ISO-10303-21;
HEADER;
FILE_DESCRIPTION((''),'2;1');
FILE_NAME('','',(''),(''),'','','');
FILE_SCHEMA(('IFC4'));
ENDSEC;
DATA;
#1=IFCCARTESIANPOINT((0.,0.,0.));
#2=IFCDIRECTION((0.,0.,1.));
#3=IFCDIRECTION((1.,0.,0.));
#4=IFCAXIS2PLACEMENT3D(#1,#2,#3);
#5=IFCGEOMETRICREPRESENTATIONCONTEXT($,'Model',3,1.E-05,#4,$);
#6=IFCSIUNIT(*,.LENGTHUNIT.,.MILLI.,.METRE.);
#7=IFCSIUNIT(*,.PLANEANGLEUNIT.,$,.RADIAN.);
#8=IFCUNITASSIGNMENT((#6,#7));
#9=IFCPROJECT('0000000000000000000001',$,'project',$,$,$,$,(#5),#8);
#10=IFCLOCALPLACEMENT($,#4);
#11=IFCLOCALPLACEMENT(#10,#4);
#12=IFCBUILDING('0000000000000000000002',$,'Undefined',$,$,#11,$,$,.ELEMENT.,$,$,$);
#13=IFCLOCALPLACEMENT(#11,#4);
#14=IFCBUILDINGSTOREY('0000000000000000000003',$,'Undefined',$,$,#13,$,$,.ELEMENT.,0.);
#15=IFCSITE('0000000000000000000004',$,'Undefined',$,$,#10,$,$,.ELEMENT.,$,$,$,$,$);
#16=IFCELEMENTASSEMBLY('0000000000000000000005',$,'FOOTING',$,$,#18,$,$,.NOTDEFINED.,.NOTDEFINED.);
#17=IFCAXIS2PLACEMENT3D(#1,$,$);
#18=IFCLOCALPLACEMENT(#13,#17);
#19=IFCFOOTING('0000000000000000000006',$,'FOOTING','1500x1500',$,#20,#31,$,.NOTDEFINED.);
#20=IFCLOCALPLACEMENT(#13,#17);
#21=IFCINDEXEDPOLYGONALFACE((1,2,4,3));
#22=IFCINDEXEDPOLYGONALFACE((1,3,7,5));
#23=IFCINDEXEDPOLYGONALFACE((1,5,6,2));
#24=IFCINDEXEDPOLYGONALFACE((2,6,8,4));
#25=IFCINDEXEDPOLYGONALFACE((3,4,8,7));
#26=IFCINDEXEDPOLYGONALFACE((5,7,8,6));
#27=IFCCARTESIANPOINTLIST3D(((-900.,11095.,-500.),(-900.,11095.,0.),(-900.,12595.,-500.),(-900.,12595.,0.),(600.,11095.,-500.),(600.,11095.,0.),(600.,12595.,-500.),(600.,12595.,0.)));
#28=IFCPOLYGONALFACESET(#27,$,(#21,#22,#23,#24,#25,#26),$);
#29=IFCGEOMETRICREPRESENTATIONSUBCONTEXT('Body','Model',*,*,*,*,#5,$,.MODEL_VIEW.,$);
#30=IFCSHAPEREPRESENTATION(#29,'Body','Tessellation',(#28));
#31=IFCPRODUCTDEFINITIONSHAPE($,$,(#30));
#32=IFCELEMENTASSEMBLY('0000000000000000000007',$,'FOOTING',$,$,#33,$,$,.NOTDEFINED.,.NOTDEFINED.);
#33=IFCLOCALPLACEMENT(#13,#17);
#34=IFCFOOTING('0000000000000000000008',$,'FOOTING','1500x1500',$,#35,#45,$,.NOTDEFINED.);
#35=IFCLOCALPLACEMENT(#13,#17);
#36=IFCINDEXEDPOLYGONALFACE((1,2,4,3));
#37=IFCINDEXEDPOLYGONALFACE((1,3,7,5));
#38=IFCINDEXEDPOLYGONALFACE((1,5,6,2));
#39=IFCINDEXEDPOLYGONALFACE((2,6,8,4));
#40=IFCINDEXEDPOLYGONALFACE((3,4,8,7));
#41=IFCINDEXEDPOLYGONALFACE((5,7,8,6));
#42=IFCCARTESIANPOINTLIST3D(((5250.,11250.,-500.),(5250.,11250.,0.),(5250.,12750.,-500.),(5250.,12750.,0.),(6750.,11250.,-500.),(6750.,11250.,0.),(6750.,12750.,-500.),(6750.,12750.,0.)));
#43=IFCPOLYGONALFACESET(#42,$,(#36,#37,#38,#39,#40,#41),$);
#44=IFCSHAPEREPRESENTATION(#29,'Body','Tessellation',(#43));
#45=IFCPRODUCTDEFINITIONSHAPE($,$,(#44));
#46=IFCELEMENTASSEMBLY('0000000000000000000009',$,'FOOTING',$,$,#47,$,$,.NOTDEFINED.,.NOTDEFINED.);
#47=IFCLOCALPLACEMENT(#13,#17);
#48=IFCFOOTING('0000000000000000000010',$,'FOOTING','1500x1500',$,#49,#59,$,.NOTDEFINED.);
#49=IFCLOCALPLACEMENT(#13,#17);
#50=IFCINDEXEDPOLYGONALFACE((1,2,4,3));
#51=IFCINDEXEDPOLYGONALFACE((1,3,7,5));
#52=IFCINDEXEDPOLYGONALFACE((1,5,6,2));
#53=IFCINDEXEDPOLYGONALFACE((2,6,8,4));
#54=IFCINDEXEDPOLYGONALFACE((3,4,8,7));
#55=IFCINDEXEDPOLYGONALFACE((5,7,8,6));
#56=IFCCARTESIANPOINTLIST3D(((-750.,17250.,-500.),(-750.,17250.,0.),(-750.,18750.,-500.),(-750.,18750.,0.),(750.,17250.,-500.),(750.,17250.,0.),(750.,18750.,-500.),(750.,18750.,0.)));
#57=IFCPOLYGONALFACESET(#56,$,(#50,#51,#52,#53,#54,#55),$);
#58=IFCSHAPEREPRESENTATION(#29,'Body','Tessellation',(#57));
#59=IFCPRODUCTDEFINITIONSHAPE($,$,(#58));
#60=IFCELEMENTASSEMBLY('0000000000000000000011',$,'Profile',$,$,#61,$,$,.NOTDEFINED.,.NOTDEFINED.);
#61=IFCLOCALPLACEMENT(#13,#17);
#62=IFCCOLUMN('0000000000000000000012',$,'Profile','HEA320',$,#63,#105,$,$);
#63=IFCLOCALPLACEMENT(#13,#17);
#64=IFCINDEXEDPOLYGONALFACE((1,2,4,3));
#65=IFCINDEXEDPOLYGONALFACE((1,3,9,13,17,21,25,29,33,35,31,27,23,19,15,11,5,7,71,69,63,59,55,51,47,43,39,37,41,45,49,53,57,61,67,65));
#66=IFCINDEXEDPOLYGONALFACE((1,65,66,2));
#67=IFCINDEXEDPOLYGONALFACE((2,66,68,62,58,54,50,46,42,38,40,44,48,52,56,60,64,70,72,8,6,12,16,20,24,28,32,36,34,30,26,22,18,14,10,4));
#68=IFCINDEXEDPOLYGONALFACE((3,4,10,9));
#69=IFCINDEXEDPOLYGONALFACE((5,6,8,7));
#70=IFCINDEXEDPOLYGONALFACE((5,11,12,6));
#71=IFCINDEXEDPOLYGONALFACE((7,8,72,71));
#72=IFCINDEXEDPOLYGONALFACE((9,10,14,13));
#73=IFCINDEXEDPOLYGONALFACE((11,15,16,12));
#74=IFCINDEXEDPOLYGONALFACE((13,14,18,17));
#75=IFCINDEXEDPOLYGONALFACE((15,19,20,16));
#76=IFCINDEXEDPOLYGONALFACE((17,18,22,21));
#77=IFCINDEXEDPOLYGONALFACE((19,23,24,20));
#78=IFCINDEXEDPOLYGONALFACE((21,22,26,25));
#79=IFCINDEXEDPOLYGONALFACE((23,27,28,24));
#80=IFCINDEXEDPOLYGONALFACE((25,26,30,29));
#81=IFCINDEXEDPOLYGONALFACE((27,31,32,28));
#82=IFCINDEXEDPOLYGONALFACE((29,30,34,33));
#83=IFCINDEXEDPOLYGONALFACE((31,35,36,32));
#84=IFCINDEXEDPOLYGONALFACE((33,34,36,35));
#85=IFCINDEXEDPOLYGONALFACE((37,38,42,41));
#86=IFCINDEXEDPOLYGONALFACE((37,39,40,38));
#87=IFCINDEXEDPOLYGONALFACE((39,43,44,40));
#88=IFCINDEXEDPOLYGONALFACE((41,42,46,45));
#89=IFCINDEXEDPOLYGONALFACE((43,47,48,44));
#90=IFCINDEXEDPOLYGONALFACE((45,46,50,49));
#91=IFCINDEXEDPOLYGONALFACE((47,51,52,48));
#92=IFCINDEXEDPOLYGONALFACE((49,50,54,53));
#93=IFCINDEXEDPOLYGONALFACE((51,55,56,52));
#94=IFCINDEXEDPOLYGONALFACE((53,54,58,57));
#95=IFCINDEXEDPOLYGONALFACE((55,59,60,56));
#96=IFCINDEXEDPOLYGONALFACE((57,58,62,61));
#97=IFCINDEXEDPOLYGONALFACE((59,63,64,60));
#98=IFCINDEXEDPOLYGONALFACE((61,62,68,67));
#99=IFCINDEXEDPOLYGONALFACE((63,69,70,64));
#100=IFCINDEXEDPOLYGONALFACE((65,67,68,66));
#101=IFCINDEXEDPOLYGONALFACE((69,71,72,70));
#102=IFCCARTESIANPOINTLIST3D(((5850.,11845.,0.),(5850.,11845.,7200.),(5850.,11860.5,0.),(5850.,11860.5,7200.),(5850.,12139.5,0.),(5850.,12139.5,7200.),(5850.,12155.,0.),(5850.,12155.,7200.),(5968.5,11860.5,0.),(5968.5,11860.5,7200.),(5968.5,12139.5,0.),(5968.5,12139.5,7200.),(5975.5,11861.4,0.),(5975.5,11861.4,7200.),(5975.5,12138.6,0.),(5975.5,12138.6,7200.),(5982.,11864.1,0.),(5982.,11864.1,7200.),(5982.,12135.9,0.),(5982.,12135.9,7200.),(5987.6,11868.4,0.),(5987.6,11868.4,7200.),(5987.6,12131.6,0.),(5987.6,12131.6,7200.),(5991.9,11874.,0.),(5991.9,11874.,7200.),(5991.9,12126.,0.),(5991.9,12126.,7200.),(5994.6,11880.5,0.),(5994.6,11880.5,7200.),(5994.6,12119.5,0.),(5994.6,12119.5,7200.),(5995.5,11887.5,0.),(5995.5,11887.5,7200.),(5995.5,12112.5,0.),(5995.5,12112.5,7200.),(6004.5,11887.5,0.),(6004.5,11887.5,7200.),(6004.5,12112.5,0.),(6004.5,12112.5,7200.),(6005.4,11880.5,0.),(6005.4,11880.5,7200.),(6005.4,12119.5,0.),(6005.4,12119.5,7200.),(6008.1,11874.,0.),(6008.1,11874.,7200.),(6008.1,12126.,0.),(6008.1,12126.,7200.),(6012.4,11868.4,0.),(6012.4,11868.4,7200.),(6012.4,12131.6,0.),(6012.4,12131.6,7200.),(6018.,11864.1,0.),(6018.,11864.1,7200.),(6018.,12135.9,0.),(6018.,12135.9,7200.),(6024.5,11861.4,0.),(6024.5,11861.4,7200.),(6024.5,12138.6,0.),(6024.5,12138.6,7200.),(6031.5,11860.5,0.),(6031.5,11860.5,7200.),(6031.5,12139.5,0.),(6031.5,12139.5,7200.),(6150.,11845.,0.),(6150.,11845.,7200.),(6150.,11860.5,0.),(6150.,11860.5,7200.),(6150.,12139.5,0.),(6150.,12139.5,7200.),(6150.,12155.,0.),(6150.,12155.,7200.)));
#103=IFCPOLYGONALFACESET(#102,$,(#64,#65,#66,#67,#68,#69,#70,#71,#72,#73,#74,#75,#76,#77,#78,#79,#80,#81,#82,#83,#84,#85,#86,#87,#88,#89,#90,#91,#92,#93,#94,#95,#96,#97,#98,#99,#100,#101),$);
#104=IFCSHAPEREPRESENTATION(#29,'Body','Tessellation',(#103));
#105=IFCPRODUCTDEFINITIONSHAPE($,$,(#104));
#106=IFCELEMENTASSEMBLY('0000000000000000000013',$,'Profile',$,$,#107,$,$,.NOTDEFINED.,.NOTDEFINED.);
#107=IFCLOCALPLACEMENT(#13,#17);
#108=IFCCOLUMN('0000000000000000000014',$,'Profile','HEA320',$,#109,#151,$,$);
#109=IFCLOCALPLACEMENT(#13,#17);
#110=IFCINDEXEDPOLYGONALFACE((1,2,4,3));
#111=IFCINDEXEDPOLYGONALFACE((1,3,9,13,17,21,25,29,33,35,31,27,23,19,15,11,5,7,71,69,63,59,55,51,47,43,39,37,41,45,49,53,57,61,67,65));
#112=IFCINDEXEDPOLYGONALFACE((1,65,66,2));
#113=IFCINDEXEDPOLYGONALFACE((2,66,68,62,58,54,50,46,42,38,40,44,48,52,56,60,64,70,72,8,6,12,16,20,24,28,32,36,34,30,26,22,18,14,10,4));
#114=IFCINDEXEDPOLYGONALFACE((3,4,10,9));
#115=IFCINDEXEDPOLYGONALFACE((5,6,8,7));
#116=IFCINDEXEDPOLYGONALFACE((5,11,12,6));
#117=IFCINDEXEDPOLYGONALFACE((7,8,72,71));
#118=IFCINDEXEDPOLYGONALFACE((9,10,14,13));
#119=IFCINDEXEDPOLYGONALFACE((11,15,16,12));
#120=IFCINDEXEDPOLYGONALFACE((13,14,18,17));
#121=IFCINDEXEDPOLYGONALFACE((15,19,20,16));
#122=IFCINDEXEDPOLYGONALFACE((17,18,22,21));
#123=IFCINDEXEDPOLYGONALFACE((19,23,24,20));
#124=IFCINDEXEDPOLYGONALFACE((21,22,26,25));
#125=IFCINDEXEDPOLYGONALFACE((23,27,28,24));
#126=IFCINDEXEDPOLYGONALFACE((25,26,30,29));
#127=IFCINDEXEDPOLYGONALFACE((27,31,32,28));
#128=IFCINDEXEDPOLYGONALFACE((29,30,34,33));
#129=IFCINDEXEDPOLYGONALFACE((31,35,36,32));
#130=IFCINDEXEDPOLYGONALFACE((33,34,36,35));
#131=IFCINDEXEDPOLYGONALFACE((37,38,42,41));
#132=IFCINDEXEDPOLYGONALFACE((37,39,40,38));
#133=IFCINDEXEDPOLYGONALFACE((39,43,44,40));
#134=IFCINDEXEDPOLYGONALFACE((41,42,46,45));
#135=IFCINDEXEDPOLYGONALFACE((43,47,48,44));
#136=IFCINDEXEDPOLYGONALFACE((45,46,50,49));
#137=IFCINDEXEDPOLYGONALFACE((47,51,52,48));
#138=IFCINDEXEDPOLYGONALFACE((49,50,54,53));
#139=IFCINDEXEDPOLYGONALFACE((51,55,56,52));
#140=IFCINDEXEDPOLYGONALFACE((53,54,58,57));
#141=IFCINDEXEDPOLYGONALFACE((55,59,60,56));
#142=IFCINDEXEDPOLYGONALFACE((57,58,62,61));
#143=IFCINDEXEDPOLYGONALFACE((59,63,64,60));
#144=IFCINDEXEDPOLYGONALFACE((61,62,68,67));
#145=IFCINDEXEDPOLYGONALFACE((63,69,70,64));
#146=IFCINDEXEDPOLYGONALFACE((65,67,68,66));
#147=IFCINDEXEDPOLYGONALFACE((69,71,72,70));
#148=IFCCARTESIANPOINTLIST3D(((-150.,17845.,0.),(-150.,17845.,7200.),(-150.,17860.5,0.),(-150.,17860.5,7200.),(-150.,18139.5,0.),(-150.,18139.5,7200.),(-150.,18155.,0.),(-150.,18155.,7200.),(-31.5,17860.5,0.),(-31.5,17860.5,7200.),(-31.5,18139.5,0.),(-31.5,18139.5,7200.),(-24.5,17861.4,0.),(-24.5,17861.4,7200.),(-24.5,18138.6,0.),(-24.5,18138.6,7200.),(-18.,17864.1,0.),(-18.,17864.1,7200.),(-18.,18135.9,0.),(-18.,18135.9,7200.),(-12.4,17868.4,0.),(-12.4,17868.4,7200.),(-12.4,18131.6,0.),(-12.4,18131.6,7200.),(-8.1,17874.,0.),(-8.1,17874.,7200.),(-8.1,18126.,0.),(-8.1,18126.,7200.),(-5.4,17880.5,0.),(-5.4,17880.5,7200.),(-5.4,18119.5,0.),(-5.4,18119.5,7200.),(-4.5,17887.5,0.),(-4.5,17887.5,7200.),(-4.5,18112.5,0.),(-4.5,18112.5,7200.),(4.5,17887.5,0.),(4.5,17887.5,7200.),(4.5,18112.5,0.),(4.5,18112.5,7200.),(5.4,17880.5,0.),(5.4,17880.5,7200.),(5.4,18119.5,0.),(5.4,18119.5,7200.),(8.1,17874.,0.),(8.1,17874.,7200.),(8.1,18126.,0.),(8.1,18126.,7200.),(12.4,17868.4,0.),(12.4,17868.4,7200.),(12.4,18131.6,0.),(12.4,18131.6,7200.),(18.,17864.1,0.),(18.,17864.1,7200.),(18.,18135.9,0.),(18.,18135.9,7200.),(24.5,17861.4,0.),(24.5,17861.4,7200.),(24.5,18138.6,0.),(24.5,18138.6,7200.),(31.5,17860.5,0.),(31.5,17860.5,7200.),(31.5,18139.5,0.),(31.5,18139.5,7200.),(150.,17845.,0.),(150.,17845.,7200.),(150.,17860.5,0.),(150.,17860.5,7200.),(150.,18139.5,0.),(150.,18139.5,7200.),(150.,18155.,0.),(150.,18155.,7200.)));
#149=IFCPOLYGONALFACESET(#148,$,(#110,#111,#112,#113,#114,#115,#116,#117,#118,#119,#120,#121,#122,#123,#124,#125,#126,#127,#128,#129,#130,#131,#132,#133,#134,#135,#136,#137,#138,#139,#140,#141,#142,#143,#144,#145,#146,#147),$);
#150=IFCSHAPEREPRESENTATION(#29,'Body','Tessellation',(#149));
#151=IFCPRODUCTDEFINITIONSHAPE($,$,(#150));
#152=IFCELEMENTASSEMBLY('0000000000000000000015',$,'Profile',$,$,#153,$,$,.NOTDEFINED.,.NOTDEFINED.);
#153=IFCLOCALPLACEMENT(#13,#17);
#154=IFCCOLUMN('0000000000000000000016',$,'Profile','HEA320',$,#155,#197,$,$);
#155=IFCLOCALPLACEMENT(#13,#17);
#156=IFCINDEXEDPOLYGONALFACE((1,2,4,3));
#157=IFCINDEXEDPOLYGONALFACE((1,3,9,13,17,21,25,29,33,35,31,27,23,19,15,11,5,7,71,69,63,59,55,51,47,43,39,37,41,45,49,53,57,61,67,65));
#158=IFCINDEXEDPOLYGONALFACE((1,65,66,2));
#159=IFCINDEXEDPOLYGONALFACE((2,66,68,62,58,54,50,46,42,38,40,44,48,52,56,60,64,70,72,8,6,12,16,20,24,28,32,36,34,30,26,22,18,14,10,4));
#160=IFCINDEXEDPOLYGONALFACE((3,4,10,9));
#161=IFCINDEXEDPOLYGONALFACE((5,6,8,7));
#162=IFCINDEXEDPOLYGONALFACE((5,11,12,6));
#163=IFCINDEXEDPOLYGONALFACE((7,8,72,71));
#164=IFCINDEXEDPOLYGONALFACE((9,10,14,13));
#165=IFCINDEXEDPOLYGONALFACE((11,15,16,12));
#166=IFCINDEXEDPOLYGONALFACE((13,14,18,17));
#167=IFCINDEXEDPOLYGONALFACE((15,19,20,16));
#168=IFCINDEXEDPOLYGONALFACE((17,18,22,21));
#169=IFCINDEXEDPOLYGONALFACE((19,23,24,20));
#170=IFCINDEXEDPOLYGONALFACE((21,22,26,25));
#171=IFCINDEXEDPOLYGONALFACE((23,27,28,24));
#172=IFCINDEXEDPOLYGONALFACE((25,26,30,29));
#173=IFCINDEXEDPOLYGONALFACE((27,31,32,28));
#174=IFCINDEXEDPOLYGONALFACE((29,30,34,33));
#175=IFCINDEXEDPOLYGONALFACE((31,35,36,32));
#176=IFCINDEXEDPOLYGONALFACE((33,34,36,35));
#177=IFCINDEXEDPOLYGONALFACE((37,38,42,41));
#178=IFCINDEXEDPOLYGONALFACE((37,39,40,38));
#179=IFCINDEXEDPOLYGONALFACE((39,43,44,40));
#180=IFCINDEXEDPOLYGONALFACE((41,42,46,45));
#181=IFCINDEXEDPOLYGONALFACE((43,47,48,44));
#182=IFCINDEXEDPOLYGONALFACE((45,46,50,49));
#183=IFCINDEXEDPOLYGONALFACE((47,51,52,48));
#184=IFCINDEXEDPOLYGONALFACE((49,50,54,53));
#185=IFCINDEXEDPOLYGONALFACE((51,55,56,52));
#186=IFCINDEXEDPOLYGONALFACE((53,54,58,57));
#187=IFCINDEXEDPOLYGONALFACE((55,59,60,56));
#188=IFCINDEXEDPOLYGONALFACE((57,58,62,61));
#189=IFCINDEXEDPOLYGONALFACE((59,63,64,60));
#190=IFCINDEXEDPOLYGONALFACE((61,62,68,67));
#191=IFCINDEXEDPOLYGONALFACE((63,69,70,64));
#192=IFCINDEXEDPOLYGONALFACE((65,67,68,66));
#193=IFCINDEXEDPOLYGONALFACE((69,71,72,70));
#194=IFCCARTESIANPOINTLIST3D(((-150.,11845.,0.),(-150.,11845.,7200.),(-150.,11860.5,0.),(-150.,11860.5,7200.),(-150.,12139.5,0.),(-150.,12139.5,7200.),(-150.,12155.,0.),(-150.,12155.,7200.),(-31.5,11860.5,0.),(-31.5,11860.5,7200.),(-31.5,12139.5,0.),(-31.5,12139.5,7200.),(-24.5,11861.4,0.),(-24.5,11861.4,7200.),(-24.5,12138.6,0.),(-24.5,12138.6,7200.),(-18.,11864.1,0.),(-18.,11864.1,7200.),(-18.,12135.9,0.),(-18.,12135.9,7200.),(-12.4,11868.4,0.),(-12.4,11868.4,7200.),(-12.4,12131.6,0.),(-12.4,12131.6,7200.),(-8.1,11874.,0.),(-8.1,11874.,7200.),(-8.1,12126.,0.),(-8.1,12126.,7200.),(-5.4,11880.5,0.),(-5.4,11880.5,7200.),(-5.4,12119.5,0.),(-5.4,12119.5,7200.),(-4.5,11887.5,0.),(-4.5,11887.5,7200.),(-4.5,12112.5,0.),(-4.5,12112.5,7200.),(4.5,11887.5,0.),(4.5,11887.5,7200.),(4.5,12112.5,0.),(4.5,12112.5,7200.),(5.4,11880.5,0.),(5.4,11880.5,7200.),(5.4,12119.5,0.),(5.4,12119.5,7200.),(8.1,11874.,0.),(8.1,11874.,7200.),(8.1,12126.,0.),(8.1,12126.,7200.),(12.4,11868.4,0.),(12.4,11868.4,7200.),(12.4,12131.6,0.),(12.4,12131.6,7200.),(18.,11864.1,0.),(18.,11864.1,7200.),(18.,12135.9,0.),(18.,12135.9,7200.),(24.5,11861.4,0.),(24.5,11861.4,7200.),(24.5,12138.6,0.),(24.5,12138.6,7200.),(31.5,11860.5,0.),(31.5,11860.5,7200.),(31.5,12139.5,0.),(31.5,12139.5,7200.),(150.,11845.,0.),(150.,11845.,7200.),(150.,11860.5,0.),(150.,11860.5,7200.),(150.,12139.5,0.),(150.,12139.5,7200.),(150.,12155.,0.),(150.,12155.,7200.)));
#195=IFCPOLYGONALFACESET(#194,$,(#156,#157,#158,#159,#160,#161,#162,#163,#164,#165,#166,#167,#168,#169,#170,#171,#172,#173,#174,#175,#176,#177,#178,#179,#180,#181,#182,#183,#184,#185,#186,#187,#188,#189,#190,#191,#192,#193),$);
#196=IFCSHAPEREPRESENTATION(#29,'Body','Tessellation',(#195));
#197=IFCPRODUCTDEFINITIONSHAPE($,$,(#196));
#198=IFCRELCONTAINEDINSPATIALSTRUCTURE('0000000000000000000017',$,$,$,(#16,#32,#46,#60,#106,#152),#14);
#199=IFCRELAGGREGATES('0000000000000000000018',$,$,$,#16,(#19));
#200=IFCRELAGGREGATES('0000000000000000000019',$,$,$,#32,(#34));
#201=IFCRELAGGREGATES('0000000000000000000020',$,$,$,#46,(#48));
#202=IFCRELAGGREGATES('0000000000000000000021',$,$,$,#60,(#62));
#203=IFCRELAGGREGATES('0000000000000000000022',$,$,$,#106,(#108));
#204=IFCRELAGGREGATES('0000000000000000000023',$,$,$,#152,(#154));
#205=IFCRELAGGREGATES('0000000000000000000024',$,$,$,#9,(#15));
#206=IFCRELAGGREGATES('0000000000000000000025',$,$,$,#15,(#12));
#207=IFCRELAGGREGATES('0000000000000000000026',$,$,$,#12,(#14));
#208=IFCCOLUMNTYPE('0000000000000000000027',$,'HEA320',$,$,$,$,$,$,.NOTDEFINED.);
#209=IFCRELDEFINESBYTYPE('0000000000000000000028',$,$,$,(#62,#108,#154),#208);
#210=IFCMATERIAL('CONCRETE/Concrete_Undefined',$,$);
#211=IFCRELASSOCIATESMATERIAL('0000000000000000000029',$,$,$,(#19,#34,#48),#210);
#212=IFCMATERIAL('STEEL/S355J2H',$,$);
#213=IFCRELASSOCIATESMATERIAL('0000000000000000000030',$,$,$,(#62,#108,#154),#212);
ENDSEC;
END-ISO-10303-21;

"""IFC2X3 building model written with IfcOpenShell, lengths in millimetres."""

from ifc_helpers import new_model, si_unit, frame, origin_with_axes, origin_2d_with_axis, place, context, subcontext, project, spatial, rectangle, i_section, extrude, material, type_object, element, aggregate, save


model = new_model("IFC2X3")

# Units and contexts
model_context = context("Model", 3, precision=1e-05, world=origin_with_axes())
body_context = subcontext(model_context, "Body", "Model", "MODEL_VIEW")
ifc_project = project(units=[si_unit("LENGTHUNIT", "METRE", prefix="MILLI"), si_unit("PLANEANGLEUNIT", "RADIAN")], contexts=[model_context])

# Site, building, storey
site_placement = place(None, origin_with_axes())
site = spatial("IfcSite", under=ifc_project, at=site_placement, Name="Undefined", CompositionType="ELEMENT")
building_placement = place(site_placement, origin_with_axes())
building = spatial("IfcBuilding", under=site, at=building_placement, Name="Undefined", CompositionType="ELEMENT")
storey_placement = place(building_placement, origin_with_axes())
storey = spatial("IfcBuildingStorey", under=building, at=storey_placement, Name="Undefined", CompositionType="ELEMENT", Elevation=0.0)

# Element assemblies, footings
assembly_1_placement = place(storey_placement, origin_with_axes())
assembly_1 = element("IfcElementAssembly", 1, at=assembly_1_placement, inside=storey, Name="FOOTING", AssemblyPlace="NOTDEFINED", PredefinedType="NOTDEFINED")
ifc_material_1 = material(Name="CONCRETE/Concrete_Undefined")
footing_1_placement = place(assembly_1_placement, frame((-150.0, 11845.0, -500.0), z_axis=(0.0, 1.0, 0.0), x_axis=(0.0, 0.0, 1.0)))
footing_1 = element("IfcFooting", 2, at=footing_1_placement, material=ifc_material_1, Name="FOOTING", Description="1500x1500", PredefinedType="NOTDEFINED", context=body_context, shape_type="SweptSolid", body=[
    extrude(rectangle(XDim=1500.0, YDim=1500.0, at=origin_2d_with_axis()), frame((500.0, 0.0, 0.0), z_axis=(-1.0, 0.0, 0.0), x_axis=(0.0, -1.0, 0.0)), (0.0, 0.0, 1.0), 500.0),
])
aggregate(assembly_1, [footing_1])
assembly_2_placement = place(storey_placement, origin_with_axes())
assembly_2 = element("IfcElementAssembly", 3, at=assembly_2_placement, inside=storey, Name="FOOTING", AssemblyPlace="NOTDEFINED", PredefinedType="NOTDEFINED")
footing_2_placement = place(assembly_2_placement, frame((6000.0, 12000.0, -500.0), z_axis=(0.0, 1.0, 0.0), x_axis=(0.0, 0.0, 1.0)))
footing_2 = element("IfcFooting", 4, at=footing_2_placement, material=ifc_material_1, Name="FOOTING", Description="1500x1500", PredefinedType="NOTDEFINED", context=body_context, shape_type="SweptSolid", body=[
    extrude(rectangle(XDim=1500.0, YDim=1500.0, at=origin_2d_with_axis()), frame((500.0, 0.0, 0.0), z_axis=(-1.0, 0.0, 0.0), x_axis=(0.0, -1.0, 0.0)), (0.0, 0.0, 1.0), 500.0),
])
aggregate(assembly_2, [footing_2])
assembly_3_placement = place(storey_placement, origin_with_axes())
assembly_3 = element("IfcElementAssembly", 5, at=assembly_3_placement, inside=storey, Name="FOOTING", AssemblyPlace="NOTDEFINED", PredefinedType="NOTDEFINED")
footing_3_placement = place(assembly_3_placement, frame((0.0, 18000.0, -500.0), z_axis=(0.0, 1.0, 0.0), x_axis=(0.0, 0.0, 1.0)))
footing_3 = element("IfcFooting", 6, at=footing_3_placement, material=ifc_material_1, Name="FOOTING", Description="1500x1500", PredefinedType="NOTDEFINED", context=body_context, shape_type="SweptSolid", body=[
    extrude(rectangle(XDim=1500.0, YDim=1500.0, at=origin_2d_with_axis()), frame((500.0, 0.0, 0.0), z_axis=(-1.0, 0.0, 0.0), x_axis=(0.0, -1.0, 0.0)), (0.0, 0.0, 1.0), 500.0),
])
aggregate(assembly_3, [footing_3])

# Element assemblies, columns
assembly_4_placement = place(storey_placement, origin_with_axes())
assembly_4 = element("IfcElementAssembly", 7, at=assembly_4_placement, inside=storey, Name="Profile", AssemblyPlace="NOTDEFINED", PredefinedType="NOTDEFINED")
ifc_material_2 = material(Name="STEEL/S355J2H")
column_type = type_object("IfcColumnType", Name="HEA320", PredefinedType="NOTDEFINED")
column_1_placement = place(assembly_4_placement, frame((6000.0, 12000.0, 0.0), z_axis=(0.0, 0.0, 1.0), x_axis=(0.0, 1.0, 0.0)))
column_1 = element("IfcColumn", 8, at=column_1_placement, type_object=column_type, material=ifc_material_2, Name="Profile", Description="HEA320", context=body_context, shape_type="SweptSolid", body=[
    extrude(i_section(OverallWidth=300.0, OverallDepth=310.0, WebThickness=9.0, FlangeThickness=15.5, FilletRadius=27.0, at=origin_2d_with_axis()), frame((0.0, 0.0, 7200.0), z_axis=(0.0, 0.0, -1.0), x_axis=(0.0, 1.0, 0.0)), (0.0, 0.0, 1.0), 7200.0),
])
aggregate(assembly_4, [column_1])
assembly_5_placement = place(storey_placement, origin_with_axes())
assembly_5 = element("IfcElementAssembly", 9, at=assembly_5_placement, inside=storey, Name="Profile", AssemblyPlace="NOTDEFINED", PredefinedType="NOTDEFINED")
column_2_placement = place(assembly_5_placement, frame((0.0, 18000.0, 0.0), z_axis=(0.0, 0.0, 1.0), x_axis=(0.0, 1.0, 0.0)))
column_2 = element("IfcColumn", 10, at=column_2_placement, type_object=column_type, material=ifc_material_2, Name="Profile", Description="HEA320", context=body_context, shape_type="SweptSolid", body=[
    extrude(i_section(OverallWidth=300.0, OverallDepth=310.0, WebThickness=9.0, FlangeThickness=15.5, FilletRadius=27.0, at=origin_2d_with_axis()), frame((0.0, 0.0, 7200.0), z_axis=(0.0, 0.0, -1.0), x_axis=(0.0, 1.0, 0.0)), (0.0, 0.0, 1.0), 7200.0),
])
aggregate(assembly_5, [column_2])
assembly_6_placement = place(storey_placement, origin_with_axes())
assembly_6 = element("IfcElementAssembly", 11, at=assembly_6_placement, inside=storey, Name="Profile", AssemblyPlace="NOTDEFINED", PredefinedType="NOTDEFINED")
column_3_placement = place(assembly_6_placement, frame((0.0, 12000.0, 0.0), z_axis=(0.0, 0.0, 1.0), x_axis=(0.0, 1.0, 0.0)))
column_3 = element("IfcColumn", 12, at=column_3_placement, type_object=column_type, material=ifc_material_2, Name="Profile", Description="HEA320", context=body_context, shape_type="SweptSolid", body=[
    extrude(i_section(OverallWidth=300.0, OverallDepth=310.0, WebThickness=9.0, FlangeThickness=15.5, FilletRadius=27.0, at=origin_2d_with_axis()), frame((0.0, 0.0, 7200.0), z_axis=(0.0, 0.0, -1.0), x_axis=(0.0, 1.0, 0.0)), (0.0, 0.0, 1.0), 7200.0),
])
aggregate(assembly_6, [column_3])

save(model, "model.ifc")
